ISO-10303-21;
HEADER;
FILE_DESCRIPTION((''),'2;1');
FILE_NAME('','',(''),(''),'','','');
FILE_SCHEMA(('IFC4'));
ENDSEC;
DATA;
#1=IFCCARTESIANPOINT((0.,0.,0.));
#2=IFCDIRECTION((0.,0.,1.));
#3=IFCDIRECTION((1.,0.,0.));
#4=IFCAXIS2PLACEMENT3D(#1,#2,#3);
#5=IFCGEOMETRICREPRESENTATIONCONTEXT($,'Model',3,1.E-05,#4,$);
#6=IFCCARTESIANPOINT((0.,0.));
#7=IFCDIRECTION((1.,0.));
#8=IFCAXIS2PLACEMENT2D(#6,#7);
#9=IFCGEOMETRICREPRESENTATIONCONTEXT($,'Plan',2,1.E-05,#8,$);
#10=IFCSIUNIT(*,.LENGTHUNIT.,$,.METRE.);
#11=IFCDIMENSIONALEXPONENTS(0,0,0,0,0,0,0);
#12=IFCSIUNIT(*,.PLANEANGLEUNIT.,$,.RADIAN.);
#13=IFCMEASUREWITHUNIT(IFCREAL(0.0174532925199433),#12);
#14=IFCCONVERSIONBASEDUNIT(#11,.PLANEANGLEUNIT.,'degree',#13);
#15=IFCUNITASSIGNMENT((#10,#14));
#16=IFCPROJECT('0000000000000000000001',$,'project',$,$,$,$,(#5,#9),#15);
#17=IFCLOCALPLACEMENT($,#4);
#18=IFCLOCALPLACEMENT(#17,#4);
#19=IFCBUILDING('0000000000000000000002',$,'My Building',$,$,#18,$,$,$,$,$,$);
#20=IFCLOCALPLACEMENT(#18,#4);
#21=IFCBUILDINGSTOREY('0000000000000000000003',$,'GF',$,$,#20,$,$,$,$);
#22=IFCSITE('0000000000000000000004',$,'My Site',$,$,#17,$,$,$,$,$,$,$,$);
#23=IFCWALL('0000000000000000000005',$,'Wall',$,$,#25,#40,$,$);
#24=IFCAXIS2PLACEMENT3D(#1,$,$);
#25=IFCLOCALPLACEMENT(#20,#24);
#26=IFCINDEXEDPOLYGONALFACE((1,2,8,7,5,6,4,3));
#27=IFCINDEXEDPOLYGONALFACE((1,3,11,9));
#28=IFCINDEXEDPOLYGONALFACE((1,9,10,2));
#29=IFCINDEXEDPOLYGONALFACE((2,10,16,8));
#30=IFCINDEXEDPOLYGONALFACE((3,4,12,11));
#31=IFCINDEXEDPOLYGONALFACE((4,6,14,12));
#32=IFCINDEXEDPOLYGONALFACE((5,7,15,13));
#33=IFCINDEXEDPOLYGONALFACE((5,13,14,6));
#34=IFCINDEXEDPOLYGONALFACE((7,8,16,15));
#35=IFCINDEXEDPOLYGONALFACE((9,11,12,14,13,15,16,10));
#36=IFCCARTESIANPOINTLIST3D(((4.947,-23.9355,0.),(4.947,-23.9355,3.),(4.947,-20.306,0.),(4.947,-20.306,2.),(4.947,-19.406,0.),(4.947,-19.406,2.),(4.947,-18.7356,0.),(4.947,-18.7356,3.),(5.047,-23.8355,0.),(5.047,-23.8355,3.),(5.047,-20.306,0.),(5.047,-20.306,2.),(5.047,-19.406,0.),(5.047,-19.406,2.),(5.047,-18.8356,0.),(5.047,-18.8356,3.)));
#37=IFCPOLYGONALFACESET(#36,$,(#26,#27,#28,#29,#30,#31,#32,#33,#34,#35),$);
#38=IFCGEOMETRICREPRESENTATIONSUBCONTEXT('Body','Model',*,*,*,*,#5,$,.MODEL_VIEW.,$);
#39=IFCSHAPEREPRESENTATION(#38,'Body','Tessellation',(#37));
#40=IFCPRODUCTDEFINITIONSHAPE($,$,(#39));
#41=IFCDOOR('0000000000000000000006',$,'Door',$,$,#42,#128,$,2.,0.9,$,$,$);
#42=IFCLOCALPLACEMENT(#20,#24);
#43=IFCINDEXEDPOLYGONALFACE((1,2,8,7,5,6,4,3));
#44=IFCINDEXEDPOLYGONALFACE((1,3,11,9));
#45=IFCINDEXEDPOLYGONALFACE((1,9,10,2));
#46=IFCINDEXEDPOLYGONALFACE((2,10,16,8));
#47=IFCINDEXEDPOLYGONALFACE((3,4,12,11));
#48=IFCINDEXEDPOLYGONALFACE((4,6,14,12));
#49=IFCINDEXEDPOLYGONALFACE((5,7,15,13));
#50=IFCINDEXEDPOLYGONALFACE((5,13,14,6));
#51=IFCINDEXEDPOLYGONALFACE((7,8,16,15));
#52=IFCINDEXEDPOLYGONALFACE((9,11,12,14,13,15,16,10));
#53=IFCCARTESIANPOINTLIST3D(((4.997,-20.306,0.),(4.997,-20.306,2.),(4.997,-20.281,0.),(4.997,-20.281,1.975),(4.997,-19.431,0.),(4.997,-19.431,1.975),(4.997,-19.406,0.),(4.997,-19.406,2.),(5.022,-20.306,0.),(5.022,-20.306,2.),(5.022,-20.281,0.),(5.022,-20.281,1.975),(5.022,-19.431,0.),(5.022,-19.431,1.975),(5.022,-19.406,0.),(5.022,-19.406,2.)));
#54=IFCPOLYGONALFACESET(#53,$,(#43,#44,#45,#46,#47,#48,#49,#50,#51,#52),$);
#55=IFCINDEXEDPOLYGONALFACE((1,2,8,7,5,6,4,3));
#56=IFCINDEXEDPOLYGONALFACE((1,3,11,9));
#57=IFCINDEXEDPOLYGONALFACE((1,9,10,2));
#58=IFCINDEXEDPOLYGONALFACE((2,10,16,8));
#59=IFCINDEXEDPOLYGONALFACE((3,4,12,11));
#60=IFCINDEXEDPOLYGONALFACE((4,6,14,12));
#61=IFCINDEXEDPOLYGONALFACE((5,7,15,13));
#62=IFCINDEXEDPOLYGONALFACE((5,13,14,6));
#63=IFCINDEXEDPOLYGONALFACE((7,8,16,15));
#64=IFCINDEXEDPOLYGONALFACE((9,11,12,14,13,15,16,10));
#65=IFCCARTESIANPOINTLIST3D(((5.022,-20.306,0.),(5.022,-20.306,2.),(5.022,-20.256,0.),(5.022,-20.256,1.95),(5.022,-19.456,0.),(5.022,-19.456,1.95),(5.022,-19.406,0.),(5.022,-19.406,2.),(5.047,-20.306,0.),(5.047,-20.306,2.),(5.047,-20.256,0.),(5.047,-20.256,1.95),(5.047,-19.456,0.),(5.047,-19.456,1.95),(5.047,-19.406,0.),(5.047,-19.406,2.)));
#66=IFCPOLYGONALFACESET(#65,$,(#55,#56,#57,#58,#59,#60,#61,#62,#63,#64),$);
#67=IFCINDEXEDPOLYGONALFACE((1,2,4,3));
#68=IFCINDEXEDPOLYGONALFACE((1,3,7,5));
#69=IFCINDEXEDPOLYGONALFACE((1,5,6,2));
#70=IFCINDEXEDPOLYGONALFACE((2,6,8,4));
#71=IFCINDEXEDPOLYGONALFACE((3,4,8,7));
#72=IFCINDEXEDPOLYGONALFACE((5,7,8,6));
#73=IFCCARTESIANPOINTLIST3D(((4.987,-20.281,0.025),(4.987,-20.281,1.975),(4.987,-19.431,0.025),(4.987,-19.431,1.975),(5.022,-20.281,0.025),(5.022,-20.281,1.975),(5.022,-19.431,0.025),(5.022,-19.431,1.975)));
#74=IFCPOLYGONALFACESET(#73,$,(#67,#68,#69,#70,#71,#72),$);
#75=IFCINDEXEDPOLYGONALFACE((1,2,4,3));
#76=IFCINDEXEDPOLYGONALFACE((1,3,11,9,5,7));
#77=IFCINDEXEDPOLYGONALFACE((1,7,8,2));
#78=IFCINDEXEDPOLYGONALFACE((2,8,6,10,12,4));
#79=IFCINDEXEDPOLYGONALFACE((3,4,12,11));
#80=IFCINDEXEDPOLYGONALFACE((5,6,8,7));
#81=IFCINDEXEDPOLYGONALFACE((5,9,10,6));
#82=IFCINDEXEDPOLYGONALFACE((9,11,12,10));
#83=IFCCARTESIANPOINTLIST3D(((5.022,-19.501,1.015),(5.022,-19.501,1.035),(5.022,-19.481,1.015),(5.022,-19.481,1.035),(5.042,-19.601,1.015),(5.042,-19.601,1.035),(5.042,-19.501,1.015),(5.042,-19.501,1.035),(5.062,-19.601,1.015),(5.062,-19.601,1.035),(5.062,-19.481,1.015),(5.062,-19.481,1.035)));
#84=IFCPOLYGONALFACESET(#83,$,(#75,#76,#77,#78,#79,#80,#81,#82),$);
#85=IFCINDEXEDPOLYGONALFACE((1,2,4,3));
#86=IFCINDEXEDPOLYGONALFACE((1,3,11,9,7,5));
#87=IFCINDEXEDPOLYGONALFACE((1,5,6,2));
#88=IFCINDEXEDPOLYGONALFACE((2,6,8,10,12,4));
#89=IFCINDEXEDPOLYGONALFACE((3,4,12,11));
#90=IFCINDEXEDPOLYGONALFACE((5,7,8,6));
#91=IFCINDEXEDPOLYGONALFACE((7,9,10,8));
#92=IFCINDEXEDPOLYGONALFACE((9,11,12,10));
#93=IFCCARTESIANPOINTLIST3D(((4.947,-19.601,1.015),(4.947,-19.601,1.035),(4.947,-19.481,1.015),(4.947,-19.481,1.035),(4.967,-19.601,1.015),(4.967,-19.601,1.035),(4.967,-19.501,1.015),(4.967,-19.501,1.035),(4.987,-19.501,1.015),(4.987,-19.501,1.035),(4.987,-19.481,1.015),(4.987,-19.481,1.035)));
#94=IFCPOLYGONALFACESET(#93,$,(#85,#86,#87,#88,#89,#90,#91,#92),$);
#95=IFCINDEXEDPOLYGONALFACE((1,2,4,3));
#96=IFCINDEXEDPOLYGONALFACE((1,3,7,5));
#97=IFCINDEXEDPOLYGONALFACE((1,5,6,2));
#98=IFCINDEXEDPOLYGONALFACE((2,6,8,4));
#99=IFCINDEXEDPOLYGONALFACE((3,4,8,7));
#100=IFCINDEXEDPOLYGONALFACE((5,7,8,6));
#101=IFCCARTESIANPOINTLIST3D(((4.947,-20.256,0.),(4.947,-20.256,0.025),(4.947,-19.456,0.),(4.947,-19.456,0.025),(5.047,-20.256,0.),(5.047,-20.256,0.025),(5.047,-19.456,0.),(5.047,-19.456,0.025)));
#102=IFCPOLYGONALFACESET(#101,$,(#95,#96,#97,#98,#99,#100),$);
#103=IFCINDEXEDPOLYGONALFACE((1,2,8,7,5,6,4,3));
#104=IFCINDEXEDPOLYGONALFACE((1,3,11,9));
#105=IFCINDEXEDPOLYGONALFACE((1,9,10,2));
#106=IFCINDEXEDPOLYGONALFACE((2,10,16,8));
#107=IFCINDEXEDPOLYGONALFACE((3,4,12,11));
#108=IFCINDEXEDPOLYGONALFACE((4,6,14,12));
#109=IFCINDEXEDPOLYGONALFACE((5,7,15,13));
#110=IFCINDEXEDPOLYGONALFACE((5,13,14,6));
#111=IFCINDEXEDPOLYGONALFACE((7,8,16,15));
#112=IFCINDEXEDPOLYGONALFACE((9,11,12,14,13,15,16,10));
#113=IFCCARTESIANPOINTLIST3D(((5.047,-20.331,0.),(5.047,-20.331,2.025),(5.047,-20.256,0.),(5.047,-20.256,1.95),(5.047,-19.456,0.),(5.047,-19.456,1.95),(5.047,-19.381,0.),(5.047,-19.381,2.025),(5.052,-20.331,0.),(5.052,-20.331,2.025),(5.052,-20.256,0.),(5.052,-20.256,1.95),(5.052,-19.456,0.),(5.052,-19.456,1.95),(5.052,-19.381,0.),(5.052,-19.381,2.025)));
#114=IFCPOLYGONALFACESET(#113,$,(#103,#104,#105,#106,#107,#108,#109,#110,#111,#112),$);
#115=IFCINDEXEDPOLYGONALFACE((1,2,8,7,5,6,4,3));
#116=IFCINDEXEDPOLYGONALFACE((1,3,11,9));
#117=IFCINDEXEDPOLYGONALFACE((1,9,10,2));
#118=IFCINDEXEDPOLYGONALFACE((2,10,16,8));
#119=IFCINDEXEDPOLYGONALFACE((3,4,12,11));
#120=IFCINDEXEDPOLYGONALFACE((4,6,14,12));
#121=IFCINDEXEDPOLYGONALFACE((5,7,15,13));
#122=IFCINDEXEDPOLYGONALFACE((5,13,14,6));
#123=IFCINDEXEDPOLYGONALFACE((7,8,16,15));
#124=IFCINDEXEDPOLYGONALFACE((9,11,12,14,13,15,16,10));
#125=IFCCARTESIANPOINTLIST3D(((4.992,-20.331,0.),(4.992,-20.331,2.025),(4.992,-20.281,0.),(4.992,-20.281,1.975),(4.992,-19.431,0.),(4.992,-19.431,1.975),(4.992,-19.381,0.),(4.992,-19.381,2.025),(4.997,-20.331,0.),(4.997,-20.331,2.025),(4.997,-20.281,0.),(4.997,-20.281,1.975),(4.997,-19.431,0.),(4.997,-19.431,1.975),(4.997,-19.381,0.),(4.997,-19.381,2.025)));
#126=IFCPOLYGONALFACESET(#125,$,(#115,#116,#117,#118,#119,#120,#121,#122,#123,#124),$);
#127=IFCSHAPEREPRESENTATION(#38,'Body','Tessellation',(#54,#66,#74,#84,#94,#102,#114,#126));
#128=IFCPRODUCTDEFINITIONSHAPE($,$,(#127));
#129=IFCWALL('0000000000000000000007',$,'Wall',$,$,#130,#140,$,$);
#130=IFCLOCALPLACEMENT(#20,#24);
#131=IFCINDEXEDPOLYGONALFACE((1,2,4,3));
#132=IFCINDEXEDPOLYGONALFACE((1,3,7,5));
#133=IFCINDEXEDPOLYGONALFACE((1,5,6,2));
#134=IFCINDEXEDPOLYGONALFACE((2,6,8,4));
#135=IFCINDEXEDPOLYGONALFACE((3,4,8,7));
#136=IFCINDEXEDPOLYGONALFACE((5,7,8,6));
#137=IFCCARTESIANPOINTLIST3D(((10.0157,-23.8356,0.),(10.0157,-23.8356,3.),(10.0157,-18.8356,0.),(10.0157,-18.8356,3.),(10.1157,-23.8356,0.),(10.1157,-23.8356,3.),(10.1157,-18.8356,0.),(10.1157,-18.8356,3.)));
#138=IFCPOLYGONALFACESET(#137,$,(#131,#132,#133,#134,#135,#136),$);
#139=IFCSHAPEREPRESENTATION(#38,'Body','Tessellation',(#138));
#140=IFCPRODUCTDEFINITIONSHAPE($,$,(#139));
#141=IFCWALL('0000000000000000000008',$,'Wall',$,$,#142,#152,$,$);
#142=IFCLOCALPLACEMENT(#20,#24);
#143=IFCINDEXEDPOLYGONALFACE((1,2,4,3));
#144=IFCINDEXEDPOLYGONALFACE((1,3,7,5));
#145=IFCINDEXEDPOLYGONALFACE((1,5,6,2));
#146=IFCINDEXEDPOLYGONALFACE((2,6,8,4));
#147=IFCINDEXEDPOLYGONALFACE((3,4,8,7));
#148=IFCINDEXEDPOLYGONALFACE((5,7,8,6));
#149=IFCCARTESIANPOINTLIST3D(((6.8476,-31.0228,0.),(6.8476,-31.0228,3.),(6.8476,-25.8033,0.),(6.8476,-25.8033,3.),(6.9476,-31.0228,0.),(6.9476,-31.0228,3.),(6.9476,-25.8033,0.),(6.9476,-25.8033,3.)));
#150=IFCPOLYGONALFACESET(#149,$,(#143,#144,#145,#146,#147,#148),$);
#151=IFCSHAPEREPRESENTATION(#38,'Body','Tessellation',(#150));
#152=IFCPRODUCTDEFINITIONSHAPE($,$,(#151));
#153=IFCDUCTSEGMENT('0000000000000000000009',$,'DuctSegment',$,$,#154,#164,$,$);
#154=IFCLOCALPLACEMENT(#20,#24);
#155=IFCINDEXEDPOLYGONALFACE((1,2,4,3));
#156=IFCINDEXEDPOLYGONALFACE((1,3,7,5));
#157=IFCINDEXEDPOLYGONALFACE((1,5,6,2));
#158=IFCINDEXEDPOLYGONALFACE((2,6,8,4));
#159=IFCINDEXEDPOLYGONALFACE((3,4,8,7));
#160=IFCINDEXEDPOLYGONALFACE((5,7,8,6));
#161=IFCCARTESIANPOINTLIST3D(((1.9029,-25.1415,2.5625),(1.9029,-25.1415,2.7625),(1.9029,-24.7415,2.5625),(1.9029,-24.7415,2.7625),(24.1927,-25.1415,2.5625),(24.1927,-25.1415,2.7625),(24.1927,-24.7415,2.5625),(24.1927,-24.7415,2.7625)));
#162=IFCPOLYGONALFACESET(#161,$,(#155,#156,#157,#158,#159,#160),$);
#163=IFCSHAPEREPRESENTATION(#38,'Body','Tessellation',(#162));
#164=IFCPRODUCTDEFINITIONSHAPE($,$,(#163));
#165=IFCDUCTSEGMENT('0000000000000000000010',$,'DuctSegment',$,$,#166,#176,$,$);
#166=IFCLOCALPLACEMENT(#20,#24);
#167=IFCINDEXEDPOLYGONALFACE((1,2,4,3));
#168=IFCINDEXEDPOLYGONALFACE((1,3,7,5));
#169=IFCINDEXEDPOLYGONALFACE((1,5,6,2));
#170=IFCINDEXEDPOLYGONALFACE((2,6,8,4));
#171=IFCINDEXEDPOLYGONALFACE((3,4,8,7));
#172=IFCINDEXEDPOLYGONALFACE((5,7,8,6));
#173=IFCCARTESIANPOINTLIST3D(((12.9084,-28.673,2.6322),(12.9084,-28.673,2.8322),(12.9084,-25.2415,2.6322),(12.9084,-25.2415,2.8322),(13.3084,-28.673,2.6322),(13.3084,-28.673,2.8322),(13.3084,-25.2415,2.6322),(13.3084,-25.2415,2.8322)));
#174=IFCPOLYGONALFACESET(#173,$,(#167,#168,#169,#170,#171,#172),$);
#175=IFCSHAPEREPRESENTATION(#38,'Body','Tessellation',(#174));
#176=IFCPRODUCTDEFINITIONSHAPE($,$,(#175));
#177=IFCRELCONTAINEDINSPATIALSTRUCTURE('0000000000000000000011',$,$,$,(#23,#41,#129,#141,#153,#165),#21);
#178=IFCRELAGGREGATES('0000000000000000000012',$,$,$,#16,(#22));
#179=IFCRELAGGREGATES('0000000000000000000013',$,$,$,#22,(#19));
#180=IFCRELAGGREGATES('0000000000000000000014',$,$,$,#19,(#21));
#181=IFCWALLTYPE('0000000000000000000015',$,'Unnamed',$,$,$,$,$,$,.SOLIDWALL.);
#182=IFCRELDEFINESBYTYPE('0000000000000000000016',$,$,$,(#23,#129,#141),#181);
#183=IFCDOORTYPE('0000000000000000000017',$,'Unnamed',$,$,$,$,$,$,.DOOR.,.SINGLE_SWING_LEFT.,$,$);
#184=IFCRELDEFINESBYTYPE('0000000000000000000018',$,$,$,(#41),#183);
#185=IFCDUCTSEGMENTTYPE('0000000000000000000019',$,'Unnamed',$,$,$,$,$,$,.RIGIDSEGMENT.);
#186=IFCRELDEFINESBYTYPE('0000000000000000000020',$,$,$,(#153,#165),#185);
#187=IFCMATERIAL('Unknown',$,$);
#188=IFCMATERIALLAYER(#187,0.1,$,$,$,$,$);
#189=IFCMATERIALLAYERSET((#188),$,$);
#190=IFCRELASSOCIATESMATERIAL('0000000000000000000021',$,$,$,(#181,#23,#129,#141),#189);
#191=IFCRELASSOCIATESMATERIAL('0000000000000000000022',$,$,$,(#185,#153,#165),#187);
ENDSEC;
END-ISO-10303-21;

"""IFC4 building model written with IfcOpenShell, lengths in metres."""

from ifc_helpers import new_model, entity, si_unit, converted_unit, frame, origin_with_axes, origin_2d_with_axis, place, context, subcontext, project, spatial, line, indexed_curve, rectangle, outline, extrude, shape, source, transform, mapped, material, layer, layer_set, layer_usage, material_profile, profile_set, profile_usage, type_object, type_shapes, element, fill, save


model = new_model("IFC4")

# Units and contexts
model_context = context("Model", 3, precision=1e-05, world=origin_with_axes())
plan_context = context("Plan", 2, precision=1e-05, world=origin_2d_with_axis())
body_context_1 = subcontext(model_context, "Body", "Model", "MODEL_VIEW")
body_context_2 = subcontext(plan_context, "Body", "Plan", "PLAN_VIEW")
ifc_project = project(units=[si_unit("LENGTHUNIT", "METRE"), converted_unit("PLANEANGLEUNIT", "degree", entity("IfcReal", 0.0174532925199433), si_unit("PLANEANGLEUNIT", "RADIAN"), dimensions=[0, 0, 0, 0, 0, 0, 0])], contexts=[model_context, plan_context])

# Site, building, storey
site_placement = place(None, origin_with_axes())
site = spatial("IfcSite", under=ifc_project, at=site_placement, Name="My Site")
building_placement = place(site_placement, origin_with_axes())
building = spatial("IfcBuilding", under=site, at=building_placement, Name="My Building")
storey_placement = place(building_placement, origin_with_axes())
storey = spatial("IfcBuildingStorey", under=building, at=storey_placement, Name="GF")

# Shared definitions
ifc_material = material(Name="Unknown")
ifc_layer = layer(ifc_material, 0.1)
ifc_layer_set = layer_set([ifc_layer])
wall_type = type_object("IfcWallType", Name="Unnamed", PredefinedType="SOLIDWALL", material=ifc_layer_set)

# Shared definitions
shared_shape_1 = source(origin_with_axes(), body_context_1, "Body", "SweptSolid", [
    extrude(outline(indexed_curve([(0.0, 0.0), (0.9, 0.0), (0.9, 2.0), (0.0, 2.0)], segments=[line(1, 2, 3, 4, 1)])), frame((0.0, -0.6, 0.0), z_axis=(0.0, -1.0, 0.0), x_axis=(1.0, 0.0, 0.0)), (0.0, 0.0, -1.0), 1.2),
])
door_type = type_object("IfcDoorType", Name="Unnamed", OperationType="SINGLE_SWING_LEFT", PredefinedType="DOOR")
shared_shape_2 = source(origin_with_axes(), body_context_1, "Body", "SweptSolid", [
    extrude(outline(indexed_curve([(0.0, 0.0), (0.0, 2.0), (0.9, 2.0), (0.9, 0.0), (0.875, 0.0), (0.875, 1.975), (0.025, 1.975), (0.025, 0.0)], segments=[line(1, 2, 3, 4, 5, 6, 7, 8, 1)])), frame((0.0, 0.025, 0.0), z_axis=(0.0, -1.0, 0.0), x_axis=(1.0, 0.0, 0.0)), (0.0, 0.0, -1.0), 0.025),
    extrude(outline(indexed_curve([(0.0, 0.0), (0.0, 2.0), (0.9, 2.0), (0.9, 0.0), (0.85, 0.0), (0.85, 1.95), (0.05, 1.95), (0.05, 0.0)], segments=[line(1, 2, 3, 4, 5, 6, 7, 8, 1)])), frame((0.0, 0.0, 0.0), z_axis=(0.0, -1.0, 0.0), x_axis=(1.0, 0.0, 0.0)), (0.0, 0.0, -1.0), 0.025),
    extrude(outline(indexed_curve([(0.0, 0.0), (0.85, 0.0), (0.85, 0.035), (0.0, 0.035)], segments=[line(1, 2, 3, 4, 1)])), frame((0.025, 0.025, 0.025), z_axis=(0.0, 0.0, 1.0), x_axis=(1.0, 0.0, 0.0)), (0.0, 0.0, 1.0), 1.95),
    extrude(outline(indexed_curve([(0.0, 0.0), (0.0, -0.04), (-0.12, -0.04), (-0.12, -0.02), (-0.02, -0.02), (-0.02, 0.0)], segments=[line(1, 2, 3, 4, 5, 6, 1)])), frame((0.825, 0.025, 1.015), z_axis=(0.0, 0.0, 1.0), x_axis=(1.0, 0.0, 0.0)), (0.0, 0.0, 1.0), 0.02),
    extrude(outline(indexed_curve([(0.0, 0.0), (0.0, 0.04), (-0.12, 0.04), (-0.12, 0.02), (-0.02, 0.02), (-0.02, 0.0)], segments=[line(1, 2, 3, 4, 5, 6, 1)])), frame((0.825, 0.06, 1.015), z_axis=(0.0, 0.0, 1.0), x_axis=(1.0, 0.0, 0.0)), (0.0, 0.0, 1.0), 0.02),
    extrude(outline(indexed_curve([(0.0, 0.0), (0.8, 0.0), (0.8, 0.1), (0.0, 0.1)], segments=[line(1, 2, 3, 4, 1)])), frame((0.05, 0.0, 0.0), z_axis=(0.0, 0.0, 1.0), x_axis=(1.0, 0.0, 0.0)), (0.0, 0.0, 1.0), 0.025),
    extrude(outline(indexed_curve([(0.0, 0.0), (0.0, 2.025), (0.95, 2.025), (0.95, 0.0), (0.875, 0.0), (0.875, 1.95), (0.075, 1.95), (0.075, 0.0)], segments=[line(1, 2, 3, 4, 5, 6, 7, 8, 1)])), frame((-0.025, -0.005, 0.0), z_axis=(0.0, -1.0, 0.0), x_axis=(1.0, 0.0, 0.0)), (0.0, 0.0, -1.0), 0.005),
    extrude(outline(indexed_curve([(0.0, 0.0), (0.0, 2.025), (0.95, 2.025), (0.95, 0.0), (0.9, 0.0), (0.9, 1.975), (0.05, 1.975), (0.05, 0.0)], segments=[line(1, 2, 3, 4, 5, 6, 7, 8, 1)])), frame((-0.025, 0.05, 0.0), z_axis=(0.0, -1.0, 0.0), x_axis=(1.0, 0.0, 0.0)), (0.0, 0.0, -1.0), 0.005),
])
shared_shape_3 = source(origin_with_axes(), body_context_2, "Body", "Curve2D", [
    entity("IfcIndexedPolyCurve", entity("IfcCartesianPointList2D", [[0.0, 0.0], [0.0, 0.05], [0.025, 0.05], [0.025, 0.025], [0.05, 0.025], [0.05, 0.0]]), [entity("IfcLineIndex", [1, 2, 3, 4, 5, 6, 1])]),
    entity("IfcIndexedPolyCurve", entity("IfcCartesianPointList2D", [[0.9, 0.0], [0.9, 0.05], [0.875, 0.05], [0.875, 0.025], [0.85, 0.025], [0.85, 0.0]]), [entity("IfcLineIndex", [1, 2, 3, 4, 5, 6, 1])]),
    entity("IfcTrimmedCurve", entity("IfcEllipse", entity("IfcAxis2Placement2D", entity("IfcCartesianPoint", [0.06, 0.05]), entity("IfcDirection", [1.0, 0.0])), 0.815, 0.85), [entity("IfcCartesianPoint", [0.875, 0.05])], [entity("IfcCartesianPoint", [0.06, 0.9])], True, "CARTESIAN"),
    entity("IfcIndexedPolyCurve", entity("IfcCartesianPointList2D", [[0.025, 0.05], [0.06, 0.05], [0.06, 0.9], [0.025, 0.9]]), [entity("IfcLineIndex", [1, 2, 3, 4, 1])]),
])
type_shapes(door_type, [shared_shape_2, shared_shape_3])

# Wall, opening, door
ifc_layer_usage_1 = layer_usage(ifc_layer_set, "AXIS2", "POSITIVE", 0.0)
wall_1_placement = place(storey_placement, frame((5.047, -23.8355, 0.0), z_axis=(0.0, 0.0, 1.0), x_axis=(0.0, 1.0, 0.0)))
wall_1 = element("IfcWall", 1, at=wall_1_placement, inside=storey, type_object=wall_type, material=ifc_layer_usage_1, Name="Wall", context=body_context_1, shape_type="SweptSolid", body=[
    extrude(outline(indexed_curve([(0.0, 0.0), (-0.1, 0.1), (5.1, 0.1), (5.0, 0.0)], segments=[line(1, 2, 3, 4, 1)])), origin_with_axes(), (0.0, 0.0, 1.0), 3.0),
])
opening_1_placement = place(wall_1_placement, frame((3.5295, 0.0, 0.0), z_axis=(0.0, 0.0, 1.0), x_axis=(1.0, 0.0, 0.0)))
opening_1 = element("IfcOpeningElement", 2, at=opening_1_placement, cuts=wall_1, PredefinedType="OPENING", context=body_context_1, shape_type="MappedRepresentation", body=[
    mapped(shared_shape_1, transform((0.0, 0.0, 0.0), x_axis=(1.0, 0.0, 0.0), y_axis=(0.0, 1.0, 0.0), z_axis=(0.0, 0.0, 1.0), scale=1.0)),
])
door_1_placement = place(opening_1_placement, frame((0.0, 0.0, 0.0), z_axis=(0.0, 0.0, 1.0), x_axis=(1.0, 0.0, 0.0)))
door_1 = element("IfcDoor", 3, at=door_1_placement, inside=storey, type_object=door_type, Name="Door", OverallHeight=2.0, OverallWidth=0.9, shapes=[
    shape(body_context_1, "Body", "MappedRepresentation", [mapped(shared_shape_2, transform((0.0, 0.0, 0.0), x_axis=(1.0, 0.0, 0.0), y_axis=(0.0, 1.0, 0.0), z_axis=(0.0, 0.0, 1.0), scale=1.0))]),
    shape(body_context_2, "Body", "MappedRepresentation", [mapped(shared_shape_3, transform((0.0, 0.0, 0.0), x_axis=(1.0, 0.0, 0.0), y_axis=(0.0, 1.0, 0.0), z_axis=(0.0, 0.0, 1.0), scale=1.0))]),
])
fill(opening_1, door_1)

# Walls
ifc_layer_usage_2 = layer_usage(ifc_layer_set, "AXIS2", "POSITIVE", 0.0)
wall_2_placement = place(storey_placement, frame((10.0157, -18.8356, 0.0), z_axis=(0.0, 0.0, 1.0), x_axis=(0.0, -1.0, 0.0)))
element("IfcWall", 4, at=wall_2_placement, inside=storey, type_object=wall_type, material=ifc_layer_usage_2, Name="Wall", context=body_context_1, shape_type="SweptSolid", body=[
    extrude(outline(indexed_curve([(0.0, 0.0), (0.0, 0.1), (5.0, 0.1), (5.0, 0.0)], segments=[line(1, 2, 3, 4, 1)])), origin_with_axes(), (0.0, 0.0, 1.0), 3.0),
])
ifc_layer_usage_3 = layer_usage(ifc_layer_set, "AXIS2", "POSITIVE", 0.0)
wall_3_placement = place(storey_placement, frame((6.8476, -25.8033, 0.0), z_axis=(0.0, 0.0, 1.0), x_axis=(0.0, -1.0, 0.0)))
element("IfcWall", 5, at=wall_3_placement, inside=storey, type_object=wall_type, material=ifc_layer_usage_3, Name="Wall", context=body_context_1, shape_type="SweptSolid", body=[
    extrude(outline(indexed_curve([(0.0, 0.0), (0.0, 0.1), (5.2195, 0.1), (5.2195, 0.0)], segments=[line(1, 2, 3, 4, 1)])), origin_with_axes(), (0.0, 0.0, 1.0), 3.0),
])

# Duct segments
ifc_material_profile_1 = material_profile(ifc_material, rectangle(XDim=0.4, YDim=0.2))
ifc_profile_set_1 = profile_set([ifc_material_profile_1])
ifc_profile_usage_1 = profile_usage(ifc_profile_set_1, cardinal=5)
duct_segment_type = type_object("IfcDuctSegmentType", Name="Unnamed", PredefinedType="RIGIDSEGMENT", material=ifc_profile_set_1)
duct_segment_1_placement = place(storey_placement, frame((1.9029, -24.9415, 2.6625), z_axis=(1.0, 0.0, 0.0), x_axis=(0.0, 1.0, 0.0)))
element("IfcDuctSegment", 6, at=duct_segment_1_placement, inside=storey, type_object=duct_segment_type, material=ifc_profile_usage_1, Name="DuctSegment", context=body_context_1, shape_type="SweptSolid", body=[
    extrude(rectangle(XDim=0.4, YDim=0.2), origin_with_axes(), (0.0, 0.0, 1.0), 22.2899),
])
ifc_profile_usage_2 = profile_usage(ifc_profile_set_1, cardinal=5)
duct_segment_2_placement = place(storey_placement, frame((13.1084, -25.2415, 2.7322), z_axis=(0.0, -1.0, 0.0), x_axis=(1.0, 0.0, 0.0)))
element("IfcDuctSegment", 7, at=duct_segment_2_placement, inside=storey, type_object=duct_segment_type, material=ifc_profile_usage_2, Name="DuctSegment", context=body_context_1, shape_type="SweptSolid", body=[
    extrude(rectangle(XDim=0.4, YDim=0.2), origin_with_axes(), (0.0, 0.0, 1.0), 3.4315),
])

save(model, "model.ifc")
